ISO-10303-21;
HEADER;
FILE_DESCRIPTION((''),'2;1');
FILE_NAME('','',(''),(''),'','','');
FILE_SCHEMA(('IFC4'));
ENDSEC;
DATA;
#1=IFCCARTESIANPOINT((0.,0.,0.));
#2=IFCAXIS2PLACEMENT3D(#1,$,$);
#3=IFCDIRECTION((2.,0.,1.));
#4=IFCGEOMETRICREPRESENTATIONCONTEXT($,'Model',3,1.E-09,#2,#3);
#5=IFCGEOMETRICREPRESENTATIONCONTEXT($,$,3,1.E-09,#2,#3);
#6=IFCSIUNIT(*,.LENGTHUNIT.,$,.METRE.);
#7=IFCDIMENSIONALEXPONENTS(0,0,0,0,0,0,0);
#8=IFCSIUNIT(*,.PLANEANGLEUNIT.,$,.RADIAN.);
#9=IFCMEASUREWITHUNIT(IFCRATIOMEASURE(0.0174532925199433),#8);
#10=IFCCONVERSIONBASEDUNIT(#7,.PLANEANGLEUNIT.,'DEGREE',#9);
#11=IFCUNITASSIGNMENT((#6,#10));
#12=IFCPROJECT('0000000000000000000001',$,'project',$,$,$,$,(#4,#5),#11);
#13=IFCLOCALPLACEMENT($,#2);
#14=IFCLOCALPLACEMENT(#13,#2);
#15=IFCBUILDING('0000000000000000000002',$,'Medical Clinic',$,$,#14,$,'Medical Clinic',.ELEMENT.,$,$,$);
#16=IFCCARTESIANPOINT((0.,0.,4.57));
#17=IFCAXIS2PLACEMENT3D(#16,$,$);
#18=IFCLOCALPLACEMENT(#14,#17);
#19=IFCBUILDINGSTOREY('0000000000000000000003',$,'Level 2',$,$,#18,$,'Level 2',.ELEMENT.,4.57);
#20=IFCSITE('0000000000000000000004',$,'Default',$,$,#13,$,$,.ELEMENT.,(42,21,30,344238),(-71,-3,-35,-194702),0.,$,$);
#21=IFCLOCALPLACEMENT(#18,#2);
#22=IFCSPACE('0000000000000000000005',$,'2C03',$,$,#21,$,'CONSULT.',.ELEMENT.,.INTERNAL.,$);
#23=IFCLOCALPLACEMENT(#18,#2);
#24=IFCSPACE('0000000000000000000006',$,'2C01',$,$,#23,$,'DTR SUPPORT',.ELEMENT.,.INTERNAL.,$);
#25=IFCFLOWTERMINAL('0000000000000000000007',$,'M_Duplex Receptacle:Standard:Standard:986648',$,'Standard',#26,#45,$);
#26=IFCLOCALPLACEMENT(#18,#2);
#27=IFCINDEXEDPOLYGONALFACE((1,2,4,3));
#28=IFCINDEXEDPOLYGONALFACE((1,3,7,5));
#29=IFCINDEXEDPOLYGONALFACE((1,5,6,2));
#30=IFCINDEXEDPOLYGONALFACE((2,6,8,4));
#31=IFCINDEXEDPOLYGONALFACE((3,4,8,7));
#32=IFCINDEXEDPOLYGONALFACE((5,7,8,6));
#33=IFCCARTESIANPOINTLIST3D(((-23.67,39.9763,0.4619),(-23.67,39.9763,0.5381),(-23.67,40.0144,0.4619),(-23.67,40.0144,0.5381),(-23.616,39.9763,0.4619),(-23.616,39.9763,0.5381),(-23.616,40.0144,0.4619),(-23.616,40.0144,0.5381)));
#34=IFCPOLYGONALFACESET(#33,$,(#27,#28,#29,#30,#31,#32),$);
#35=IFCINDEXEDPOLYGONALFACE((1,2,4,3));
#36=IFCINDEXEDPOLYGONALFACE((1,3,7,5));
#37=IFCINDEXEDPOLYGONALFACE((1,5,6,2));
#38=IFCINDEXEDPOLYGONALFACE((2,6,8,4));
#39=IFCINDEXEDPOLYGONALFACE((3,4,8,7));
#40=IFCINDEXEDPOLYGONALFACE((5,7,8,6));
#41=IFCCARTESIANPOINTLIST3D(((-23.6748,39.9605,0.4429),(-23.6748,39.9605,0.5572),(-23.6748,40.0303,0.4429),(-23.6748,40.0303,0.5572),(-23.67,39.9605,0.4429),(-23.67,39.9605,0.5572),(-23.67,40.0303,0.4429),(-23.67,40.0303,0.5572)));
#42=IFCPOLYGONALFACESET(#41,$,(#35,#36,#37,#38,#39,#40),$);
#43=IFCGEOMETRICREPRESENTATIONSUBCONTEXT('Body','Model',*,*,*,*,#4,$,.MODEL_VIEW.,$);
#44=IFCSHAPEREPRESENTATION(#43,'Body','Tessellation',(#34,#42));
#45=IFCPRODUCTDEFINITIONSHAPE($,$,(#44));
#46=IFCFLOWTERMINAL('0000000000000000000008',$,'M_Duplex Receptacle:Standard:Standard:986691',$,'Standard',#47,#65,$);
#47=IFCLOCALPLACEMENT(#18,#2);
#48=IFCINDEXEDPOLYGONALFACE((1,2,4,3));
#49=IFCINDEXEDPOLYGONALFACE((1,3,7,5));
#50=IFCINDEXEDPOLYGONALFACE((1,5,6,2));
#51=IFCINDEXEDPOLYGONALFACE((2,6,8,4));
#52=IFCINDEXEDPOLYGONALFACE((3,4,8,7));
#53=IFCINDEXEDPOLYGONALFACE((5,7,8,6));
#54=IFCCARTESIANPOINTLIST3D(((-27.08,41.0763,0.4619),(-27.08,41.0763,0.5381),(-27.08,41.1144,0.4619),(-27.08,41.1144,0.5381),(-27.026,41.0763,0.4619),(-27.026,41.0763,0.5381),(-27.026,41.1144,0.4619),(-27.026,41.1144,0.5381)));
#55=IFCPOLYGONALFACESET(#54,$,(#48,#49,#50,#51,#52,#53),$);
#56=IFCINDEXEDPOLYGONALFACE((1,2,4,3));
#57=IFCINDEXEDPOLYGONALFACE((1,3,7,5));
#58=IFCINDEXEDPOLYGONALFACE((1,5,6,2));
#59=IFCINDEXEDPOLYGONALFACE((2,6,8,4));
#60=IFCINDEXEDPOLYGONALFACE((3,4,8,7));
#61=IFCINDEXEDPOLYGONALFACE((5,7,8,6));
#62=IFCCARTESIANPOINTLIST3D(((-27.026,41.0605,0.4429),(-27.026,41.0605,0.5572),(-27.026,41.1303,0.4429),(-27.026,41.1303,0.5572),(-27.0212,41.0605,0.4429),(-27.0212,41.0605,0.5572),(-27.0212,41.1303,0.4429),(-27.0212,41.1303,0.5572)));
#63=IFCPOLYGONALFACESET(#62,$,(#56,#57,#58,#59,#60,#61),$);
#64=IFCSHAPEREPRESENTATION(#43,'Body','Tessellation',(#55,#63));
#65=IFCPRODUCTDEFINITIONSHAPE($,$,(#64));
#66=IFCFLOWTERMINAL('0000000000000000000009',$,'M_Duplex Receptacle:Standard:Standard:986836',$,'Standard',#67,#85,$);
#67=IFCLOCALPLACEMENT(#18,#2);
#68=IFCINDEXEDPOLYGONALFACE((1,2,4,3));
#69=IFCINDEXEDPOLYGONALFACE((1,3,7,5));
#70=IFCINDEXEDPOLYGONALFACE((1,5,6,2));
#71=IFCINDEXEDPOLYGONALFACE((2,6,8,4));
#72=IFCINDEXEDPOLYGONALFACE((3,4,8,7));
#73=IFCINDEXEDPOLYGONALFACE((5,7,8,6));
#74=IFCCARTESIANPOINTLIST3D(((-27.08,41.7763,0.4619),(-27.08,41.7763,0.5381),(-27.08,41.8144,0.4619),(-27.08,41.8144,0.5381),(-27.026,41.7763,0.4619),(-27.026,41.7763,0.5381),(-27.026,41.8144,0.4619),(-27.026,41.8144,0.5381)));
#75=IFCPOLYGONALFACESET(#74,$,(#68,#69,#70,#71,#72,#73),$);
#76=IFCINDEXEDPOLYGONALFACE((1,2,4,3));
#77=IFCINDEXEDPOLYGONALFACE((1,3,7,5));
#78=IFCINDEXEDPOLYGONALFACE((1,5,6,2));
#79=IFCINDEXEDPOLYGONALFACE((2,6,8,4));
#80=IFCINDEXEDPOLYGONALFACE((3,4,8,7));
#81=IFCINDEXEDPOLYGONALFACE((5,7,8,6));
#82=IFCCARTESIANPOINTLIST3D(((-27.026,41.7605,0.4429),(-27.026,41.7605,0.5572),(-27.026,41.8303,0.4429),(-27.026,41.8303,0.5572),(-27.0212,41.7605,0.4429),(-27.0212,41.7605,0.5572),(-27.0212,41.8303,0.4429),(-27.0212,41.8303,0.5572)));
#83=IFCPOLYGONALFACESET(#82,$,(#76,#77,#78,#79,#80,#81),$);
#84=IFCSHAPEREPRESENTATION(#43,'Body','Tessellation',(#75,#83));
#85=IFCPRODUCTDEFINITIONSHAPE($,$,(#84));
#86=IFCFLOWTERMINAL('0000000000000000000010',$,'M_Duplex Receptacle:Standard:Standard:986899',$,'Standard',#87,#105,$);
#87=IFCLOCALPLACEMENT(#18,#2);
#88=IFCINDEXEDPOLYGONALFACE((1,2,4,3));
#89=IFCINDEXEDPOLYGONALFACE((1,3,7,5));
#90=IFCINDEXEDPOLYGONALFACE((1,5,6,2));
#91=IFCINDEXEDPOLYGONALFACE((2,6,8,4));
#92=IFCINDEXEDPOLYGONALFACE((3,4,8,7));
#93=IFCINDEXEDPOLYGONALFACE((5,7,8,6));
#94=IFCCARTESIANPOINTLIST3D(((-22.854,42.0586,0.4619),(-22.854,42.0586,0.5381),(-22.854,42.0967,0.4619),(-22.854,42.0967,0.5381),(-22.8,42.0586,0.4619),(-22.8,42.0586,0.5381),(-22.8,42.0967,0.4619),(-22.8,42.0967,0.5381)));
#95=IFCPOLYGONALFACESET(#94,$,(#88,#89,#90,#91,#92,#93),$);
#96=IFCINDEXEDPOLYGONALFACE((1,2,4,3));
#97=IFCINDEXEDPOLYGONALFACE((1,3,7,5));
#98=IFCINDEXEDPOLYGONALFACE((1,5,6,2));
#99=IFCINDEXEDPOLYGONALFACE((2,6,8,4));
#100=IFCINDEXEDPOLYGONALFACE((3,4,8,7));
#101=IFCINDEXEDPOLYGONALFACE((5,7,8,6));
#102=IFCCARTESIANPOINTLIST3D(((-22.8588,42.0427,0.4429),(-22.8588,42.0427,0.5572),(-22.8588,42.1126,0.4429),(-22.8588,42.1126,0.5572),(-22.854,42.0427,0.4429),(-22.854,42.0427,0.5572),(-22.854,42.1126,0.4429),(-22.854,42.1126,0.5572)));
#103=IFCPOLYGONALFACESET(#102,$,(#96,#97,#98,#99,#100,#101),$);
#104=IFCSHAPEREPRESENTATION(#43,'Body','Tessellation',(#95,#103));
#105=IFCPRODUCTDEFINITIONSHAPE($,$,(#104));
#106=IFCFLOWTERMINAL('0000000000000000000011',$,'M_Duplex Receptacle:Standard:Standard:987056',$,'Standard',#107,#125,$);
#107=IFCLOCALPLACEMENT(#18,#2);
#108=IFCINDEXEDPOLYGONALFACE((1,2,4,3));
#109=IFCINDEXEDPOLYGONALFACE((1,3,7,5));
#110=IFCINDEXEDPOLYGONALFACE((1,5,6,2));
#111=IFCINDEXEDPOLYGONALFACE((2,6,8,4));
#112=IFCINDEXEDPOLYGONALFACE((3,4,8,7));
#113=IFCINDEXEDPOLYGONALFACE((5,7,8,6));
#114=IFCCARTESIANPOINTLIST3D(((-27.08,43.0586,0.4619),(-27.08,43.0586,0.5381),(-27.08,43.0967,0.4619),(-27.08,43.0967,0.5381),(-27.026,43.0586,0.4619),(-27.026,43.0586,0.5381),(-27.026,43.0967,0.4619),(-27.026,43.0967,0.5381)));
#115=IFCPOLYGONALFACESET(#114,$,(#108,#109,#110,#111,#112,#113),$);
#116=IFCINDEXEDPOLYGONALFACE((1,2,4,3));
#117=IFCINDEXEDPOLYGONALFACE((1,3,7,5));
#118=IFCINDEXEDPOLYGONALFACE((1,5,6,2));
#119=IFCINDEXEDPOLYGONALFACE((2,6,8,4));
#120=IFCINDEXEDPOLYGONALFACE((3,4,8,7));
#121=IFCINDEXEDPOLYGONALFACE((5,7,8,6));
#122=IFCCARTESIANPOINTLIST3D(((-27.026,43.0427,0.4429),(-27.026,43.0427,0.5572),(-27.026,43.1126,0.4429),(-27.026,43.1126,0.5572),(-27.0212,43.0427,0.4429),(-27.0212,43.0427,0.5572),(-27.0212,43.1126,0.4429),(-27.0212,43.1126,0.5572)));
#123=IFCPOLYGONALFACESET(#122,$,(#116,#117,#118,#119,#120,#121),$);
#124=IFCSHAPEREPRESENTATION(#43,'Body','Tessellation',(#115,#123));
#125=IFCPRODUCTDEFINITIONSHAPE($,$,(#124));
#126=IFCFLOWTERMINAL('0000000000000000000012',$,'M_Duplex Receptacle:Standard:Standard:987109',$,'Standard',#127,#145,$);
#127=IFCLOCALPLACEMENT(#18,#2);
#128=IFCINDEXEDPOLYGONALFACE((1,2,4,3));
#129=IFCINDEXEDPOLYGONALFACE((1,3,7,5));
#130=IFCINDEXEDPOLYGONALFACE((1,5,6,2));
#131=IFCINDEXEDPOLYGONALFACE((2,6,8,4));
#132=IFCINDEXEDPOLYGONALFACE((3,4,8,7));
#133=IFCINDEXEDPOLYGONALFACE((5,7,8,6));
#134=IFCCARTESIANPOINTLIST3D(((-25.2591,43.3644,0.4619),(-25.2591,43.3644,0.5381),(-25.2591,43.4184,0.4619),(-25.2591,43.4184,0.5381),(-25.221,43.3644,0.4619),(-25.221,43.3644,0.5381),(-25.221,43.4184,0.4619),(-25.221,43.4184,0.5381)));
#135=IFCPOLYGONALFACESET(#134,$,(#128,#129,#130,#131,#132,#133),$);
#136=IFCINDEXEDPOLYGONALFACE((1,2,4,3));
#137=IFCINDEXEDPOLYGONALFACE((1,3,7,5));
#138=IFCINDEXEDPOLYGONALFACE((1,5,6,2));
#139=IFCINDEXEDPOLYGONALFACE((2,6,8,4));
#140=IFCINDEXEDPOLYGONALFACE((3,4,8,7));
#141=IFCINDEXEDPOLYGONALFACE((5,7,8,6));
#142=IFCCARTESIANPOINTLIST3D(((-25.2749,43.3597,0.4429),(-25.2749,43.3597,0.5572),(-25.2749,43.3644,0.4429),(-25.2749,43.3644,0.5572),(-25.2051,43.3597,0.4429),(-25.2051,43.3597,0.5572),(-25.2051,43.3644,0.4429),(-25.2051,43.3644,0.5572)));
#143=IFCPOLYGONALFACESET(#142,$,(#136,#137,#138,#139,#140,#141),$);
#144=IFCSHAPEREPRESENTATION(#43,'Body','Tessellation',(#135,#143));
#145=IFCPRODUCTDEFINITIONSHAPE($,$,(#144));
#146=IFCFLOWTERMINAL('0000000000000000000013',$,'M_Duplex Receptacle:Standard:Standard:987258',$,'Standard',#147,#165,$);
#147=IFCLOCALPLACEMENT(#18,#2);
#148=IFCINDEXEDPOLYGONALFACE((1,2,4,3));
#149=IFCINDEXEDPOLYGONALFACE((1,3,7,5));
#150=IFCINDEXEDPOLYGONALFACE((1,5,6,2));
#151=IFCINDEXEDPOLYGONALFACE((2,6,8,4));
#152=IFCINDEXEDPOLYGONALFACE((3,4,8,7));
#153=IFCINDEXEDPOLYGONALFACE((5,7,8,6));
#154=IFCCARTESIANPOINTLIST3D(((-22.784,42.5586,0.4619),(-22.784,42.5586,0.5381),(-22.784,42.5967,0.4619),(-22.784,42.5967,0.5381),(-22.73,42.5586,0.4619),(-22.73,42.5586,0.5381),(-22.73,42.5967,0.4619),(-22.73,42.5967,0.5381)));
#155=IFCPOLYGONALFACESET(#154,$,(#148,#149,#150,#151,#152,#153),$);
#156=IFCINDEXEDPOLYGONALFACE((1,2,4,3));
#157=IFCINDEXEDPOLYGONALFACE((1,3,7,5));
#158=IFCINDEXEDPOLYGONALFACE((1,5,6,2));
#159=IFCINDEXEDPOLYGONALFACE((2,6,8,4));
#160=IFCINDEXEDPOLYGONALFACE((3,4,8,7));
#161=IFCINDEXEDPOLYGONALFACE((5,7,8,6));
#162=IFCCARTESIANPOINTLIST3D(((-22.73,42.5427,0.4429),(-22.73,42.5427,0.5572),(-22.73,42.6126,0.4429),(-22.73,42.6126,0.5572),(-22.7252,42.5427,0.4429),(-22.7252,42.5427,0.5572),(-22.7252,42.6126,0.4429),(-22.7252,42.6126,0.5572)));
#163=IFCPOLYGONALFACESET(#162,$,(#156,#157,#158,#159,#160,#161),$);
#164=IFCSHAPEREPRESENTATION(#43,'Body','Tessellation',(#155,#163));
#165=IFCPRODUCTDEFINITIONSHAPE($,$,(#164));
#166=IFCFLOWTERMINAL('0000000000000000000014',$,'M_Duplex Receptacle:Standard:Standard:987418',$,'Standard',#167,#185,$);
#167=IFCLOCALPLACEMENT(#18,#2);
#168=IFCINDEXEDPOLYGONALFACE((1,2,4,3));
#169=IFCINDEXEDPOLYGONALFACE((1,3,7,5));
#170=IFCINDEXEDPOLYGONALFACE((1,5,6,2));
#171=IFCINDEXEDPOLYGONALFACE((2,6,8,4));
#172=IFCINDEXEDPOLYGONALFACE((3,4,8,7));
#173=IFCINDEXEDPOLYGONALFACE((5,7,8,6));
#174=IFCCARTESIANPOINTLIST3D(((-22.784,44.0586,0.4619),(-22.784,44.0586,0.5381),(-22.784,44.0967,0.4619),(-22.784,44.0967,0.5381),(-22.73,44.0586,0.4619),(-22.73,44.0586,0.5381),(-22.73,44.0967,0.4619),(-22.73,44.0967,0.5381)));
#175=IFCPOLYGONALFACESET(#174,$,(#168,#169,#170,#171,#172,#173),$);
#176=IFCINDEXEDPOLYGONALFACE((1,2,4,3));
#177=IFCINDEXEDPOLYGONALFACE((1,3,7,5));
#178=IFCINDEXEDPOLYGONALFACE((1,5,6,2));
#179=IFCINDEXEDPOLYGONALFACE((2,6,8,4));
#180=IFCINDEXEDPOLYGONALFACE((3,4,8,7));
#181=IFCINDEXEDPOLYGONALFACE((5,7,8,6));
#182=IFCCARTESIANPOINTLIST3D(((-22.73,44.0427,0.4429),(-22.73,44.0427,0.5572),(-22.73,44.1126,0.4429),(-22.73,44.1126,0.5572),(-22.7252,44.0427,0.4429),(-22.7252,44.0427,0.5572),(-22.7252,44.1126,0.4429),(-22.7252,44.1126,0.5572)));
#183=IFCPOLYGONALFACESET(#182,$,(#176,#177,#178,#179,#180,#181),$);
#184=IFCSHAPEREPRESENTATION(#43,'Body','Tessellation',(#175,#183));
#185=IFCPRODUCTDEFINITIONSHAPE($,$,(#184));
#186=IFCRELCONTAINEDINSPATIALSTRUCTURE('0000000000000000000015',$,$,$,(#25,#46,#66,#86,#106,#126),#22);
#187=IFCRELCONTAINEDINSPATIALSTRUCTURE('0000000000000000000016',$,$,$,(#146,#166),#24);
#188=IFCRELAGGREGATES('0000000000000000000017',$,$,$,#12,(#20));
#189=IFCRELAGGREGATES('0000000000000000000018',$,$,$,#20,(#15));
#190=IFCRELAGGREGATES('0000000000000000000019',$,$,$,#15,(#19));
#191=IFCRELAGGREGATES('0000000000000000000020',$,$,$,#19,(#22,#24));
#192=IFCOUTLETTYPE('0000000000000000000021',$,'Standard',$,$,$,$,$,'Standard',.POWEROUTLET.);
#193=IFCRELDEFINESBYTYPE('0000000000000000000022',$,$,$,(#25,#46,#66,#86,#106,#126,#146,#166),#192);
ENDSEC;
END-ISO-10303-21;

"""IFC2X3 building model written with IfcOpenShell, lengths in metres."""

from ifc_helpers import new_model, entity, si_unit, converted_unit, direction, frame, frame_2d, origin, origin_2d_with_axis, place, context, subcontext, project, spatial, rectangle, extrude, source, transform, mapped, type_object, type_shapes, element, save


model = new_model("IFC2X3")

# Units and contexts
model_context = context("Model", 3, precision=1e-09, world=origin(), true_north=direction((2.0, 0.0, 1.0)))
context_of_model = context(None, 3, precision=1e-09, world=origin(), true_north=direction((2.0, 0.0, 1.0)))
body_context = subcontext(model_context, "Body", "Model", "MODEL_VIEW")
ifc_project = project(units=[si_unit("LENGTHUNIT", "METRE"), converted_unit("PLANEANGLEUNIT", "DEGREE", entity("IfcRatioMeasure", 0.0174532925199433), si_unit("PLANEANGLEUNIT", "RADIAN"), dimensions=[0, 0, 0, 0, 0, 0, 0])], contexts=[model_context, context_of_model])

# Site, building, storey
site_placement = place(None, origin())
site = spatial("IfcSite", under=ifc_project, at=site_placement, Name="Default", CompositionType="ELEMENT", RefLatitude=(42, 21, 30, 344238), RefLongitude=(-71, -3, -35, -194702), RefElevation=0.0)
building_placement = place(site_placement, origin())
building = spatial("IfcBuilding", under=site, at=building_placement, Name="Medical Clinic", LongName="Medical Clinic", CompositionType="ELEMENT")
storey_placement = place(building_placement, frame((0.0, 0.0, 4.57)))
storey = spatial("IfcBuildingStorey", under=building, at=storey_placement, Name="Level 2", LongName="Level 2", CompositionType="ELEMENT", Elevation=4.57)

# Shared definitions
space_1_placement = place(storey_placement, origin())
space_1 = spatial("IfcSpace", under=storey, at=space_1_placement, Name="2C03", LongName="CONSULT.", CompositionType="ELEMENT", InteriorOrExteriorSpace="INTERNAL")

# Flow terminals
outlet_type = type_object("IfcOutletType", Name="Standard", ElementType="Standard", PredefinedType="POWEROUTLET")
shared_shape_1 = source(origin(), body_context, "Body", "SweptSolid", [
    extrude(rectangle(XDim=0.0381, YDim=0.0762, at=origin_2d_with_axis()), frame((0.0, 0.0, -0.054), z_axis=(0.0, 0.0, 1.0), x_axis=(-1.0, 0.0, 0.0)), (0.0, 0.0, 1.0), 0.054),
    extrude(rectangle(XDim=0.0698, YDim=0.1143, at=frame_2d((0.0, 0.0), x_axis=(1.0, 0.0))), frame((0.0, 0.0, 0.0), z_axis=(0.0, 0.0, 1.0), x_axis=(-1.0, 0.0, 0.0)), (0.0, 0.0, 1.0), 0.0048),
])
type_shapes(outlet_type, [shared_shape_1])
for number, where, z_axis, x_axis, name in (
    (1, (-23.67, 39.9954, 0.5), (-1.0, 0.0, 0.0), (0.0, -1.0, 0.0), "M_Duplex Receptacle:Standard:Standard:986648"),
    (2, (-27.026, 41.0954, 0.5), (1.0, 0.0, 0.0), (0.0, 1.0, 0.0), "M_Duplex Receptacle:Standard:Standard:986691"),
    (3, (-27.026, 41.7954, 0.5), (1.0, 0.0, 0.0), (0.0, 1.0, 0.0), "M_Duplex Receptacle:Standard:Standard:986836"),
    (4, (-22.854, 42.0776, 0.5), (-1.0, 0.0, 0.0), (0.0, -1.0, 0.0), "M_Duplex Receptacle:Standard:Standard:986899"),
    (5, (-27.026, 43.0776, 0.5), (1.0, 0.0, 0.0), (0.0, 1.0, 0.0), "M_Duplex Receptacle:Standard:Standard:987056"),
    (6, (-25.24, 43.3644, 0.5), (0.0, -1.0, 0.0), (1.0, 0.0, 0.0), "M_Duplex Receptacle:Standard:Standard:987109"),
):
    element("IfcFlowTerminal", number, at=place(space_1_placement, frame(where, z_axis=z_axis, x_axis=x_axis)), inside=space_1, type_object=outlet_type, Name=name, ObjectType="Standard", context=body_context, shape_type="MappedRepresentation", body=[
        mapped(shared_shape_1, transform((0.0, 0.0, 0.0), scale=1.0)),
    ])

# Shared definitions
space_2_placement = place(storey_placement, origin())
space_2 = spatial("IfcSpace", under=storey, at=space_2_placement, Name="2C01", LongName="DTR SUPPORT", CompositionType="ELEMENT", InteriorOrExteriorSpace="INTERNAL")

# Flow terminals
for number, where, z_axis, x_axis, name in (
    (7, (-22.73, 42.5776, 0.5), (1.0, 0.0, 0.0), (0.0, 1.0, 0.0), "M_Duplex Receptacle:Standard:Standard:987258"),
    (8, (-22.73, 44.0776, 0.5), (1.0, 0.0, 0.0), (0.0, 1.0, 0.0), "M_Duplex Receptacle:Standard:Standard:987418"),
):
    element("IfcFlowTerminal", number, at=place(space_2_placement, frame(where, z_axis=z_axis, x_axis=x_axis)), inside=space_2, type_object=outlet_type, Name=name, ObjectType="Standard", context=body_context, shape_type="MappedRepresentation", body=[
        mapped(shared_shape_1, transform((0.0, 0.0, 0.0), scale=1.0)),
    ])

save(model, "model.ifc")
